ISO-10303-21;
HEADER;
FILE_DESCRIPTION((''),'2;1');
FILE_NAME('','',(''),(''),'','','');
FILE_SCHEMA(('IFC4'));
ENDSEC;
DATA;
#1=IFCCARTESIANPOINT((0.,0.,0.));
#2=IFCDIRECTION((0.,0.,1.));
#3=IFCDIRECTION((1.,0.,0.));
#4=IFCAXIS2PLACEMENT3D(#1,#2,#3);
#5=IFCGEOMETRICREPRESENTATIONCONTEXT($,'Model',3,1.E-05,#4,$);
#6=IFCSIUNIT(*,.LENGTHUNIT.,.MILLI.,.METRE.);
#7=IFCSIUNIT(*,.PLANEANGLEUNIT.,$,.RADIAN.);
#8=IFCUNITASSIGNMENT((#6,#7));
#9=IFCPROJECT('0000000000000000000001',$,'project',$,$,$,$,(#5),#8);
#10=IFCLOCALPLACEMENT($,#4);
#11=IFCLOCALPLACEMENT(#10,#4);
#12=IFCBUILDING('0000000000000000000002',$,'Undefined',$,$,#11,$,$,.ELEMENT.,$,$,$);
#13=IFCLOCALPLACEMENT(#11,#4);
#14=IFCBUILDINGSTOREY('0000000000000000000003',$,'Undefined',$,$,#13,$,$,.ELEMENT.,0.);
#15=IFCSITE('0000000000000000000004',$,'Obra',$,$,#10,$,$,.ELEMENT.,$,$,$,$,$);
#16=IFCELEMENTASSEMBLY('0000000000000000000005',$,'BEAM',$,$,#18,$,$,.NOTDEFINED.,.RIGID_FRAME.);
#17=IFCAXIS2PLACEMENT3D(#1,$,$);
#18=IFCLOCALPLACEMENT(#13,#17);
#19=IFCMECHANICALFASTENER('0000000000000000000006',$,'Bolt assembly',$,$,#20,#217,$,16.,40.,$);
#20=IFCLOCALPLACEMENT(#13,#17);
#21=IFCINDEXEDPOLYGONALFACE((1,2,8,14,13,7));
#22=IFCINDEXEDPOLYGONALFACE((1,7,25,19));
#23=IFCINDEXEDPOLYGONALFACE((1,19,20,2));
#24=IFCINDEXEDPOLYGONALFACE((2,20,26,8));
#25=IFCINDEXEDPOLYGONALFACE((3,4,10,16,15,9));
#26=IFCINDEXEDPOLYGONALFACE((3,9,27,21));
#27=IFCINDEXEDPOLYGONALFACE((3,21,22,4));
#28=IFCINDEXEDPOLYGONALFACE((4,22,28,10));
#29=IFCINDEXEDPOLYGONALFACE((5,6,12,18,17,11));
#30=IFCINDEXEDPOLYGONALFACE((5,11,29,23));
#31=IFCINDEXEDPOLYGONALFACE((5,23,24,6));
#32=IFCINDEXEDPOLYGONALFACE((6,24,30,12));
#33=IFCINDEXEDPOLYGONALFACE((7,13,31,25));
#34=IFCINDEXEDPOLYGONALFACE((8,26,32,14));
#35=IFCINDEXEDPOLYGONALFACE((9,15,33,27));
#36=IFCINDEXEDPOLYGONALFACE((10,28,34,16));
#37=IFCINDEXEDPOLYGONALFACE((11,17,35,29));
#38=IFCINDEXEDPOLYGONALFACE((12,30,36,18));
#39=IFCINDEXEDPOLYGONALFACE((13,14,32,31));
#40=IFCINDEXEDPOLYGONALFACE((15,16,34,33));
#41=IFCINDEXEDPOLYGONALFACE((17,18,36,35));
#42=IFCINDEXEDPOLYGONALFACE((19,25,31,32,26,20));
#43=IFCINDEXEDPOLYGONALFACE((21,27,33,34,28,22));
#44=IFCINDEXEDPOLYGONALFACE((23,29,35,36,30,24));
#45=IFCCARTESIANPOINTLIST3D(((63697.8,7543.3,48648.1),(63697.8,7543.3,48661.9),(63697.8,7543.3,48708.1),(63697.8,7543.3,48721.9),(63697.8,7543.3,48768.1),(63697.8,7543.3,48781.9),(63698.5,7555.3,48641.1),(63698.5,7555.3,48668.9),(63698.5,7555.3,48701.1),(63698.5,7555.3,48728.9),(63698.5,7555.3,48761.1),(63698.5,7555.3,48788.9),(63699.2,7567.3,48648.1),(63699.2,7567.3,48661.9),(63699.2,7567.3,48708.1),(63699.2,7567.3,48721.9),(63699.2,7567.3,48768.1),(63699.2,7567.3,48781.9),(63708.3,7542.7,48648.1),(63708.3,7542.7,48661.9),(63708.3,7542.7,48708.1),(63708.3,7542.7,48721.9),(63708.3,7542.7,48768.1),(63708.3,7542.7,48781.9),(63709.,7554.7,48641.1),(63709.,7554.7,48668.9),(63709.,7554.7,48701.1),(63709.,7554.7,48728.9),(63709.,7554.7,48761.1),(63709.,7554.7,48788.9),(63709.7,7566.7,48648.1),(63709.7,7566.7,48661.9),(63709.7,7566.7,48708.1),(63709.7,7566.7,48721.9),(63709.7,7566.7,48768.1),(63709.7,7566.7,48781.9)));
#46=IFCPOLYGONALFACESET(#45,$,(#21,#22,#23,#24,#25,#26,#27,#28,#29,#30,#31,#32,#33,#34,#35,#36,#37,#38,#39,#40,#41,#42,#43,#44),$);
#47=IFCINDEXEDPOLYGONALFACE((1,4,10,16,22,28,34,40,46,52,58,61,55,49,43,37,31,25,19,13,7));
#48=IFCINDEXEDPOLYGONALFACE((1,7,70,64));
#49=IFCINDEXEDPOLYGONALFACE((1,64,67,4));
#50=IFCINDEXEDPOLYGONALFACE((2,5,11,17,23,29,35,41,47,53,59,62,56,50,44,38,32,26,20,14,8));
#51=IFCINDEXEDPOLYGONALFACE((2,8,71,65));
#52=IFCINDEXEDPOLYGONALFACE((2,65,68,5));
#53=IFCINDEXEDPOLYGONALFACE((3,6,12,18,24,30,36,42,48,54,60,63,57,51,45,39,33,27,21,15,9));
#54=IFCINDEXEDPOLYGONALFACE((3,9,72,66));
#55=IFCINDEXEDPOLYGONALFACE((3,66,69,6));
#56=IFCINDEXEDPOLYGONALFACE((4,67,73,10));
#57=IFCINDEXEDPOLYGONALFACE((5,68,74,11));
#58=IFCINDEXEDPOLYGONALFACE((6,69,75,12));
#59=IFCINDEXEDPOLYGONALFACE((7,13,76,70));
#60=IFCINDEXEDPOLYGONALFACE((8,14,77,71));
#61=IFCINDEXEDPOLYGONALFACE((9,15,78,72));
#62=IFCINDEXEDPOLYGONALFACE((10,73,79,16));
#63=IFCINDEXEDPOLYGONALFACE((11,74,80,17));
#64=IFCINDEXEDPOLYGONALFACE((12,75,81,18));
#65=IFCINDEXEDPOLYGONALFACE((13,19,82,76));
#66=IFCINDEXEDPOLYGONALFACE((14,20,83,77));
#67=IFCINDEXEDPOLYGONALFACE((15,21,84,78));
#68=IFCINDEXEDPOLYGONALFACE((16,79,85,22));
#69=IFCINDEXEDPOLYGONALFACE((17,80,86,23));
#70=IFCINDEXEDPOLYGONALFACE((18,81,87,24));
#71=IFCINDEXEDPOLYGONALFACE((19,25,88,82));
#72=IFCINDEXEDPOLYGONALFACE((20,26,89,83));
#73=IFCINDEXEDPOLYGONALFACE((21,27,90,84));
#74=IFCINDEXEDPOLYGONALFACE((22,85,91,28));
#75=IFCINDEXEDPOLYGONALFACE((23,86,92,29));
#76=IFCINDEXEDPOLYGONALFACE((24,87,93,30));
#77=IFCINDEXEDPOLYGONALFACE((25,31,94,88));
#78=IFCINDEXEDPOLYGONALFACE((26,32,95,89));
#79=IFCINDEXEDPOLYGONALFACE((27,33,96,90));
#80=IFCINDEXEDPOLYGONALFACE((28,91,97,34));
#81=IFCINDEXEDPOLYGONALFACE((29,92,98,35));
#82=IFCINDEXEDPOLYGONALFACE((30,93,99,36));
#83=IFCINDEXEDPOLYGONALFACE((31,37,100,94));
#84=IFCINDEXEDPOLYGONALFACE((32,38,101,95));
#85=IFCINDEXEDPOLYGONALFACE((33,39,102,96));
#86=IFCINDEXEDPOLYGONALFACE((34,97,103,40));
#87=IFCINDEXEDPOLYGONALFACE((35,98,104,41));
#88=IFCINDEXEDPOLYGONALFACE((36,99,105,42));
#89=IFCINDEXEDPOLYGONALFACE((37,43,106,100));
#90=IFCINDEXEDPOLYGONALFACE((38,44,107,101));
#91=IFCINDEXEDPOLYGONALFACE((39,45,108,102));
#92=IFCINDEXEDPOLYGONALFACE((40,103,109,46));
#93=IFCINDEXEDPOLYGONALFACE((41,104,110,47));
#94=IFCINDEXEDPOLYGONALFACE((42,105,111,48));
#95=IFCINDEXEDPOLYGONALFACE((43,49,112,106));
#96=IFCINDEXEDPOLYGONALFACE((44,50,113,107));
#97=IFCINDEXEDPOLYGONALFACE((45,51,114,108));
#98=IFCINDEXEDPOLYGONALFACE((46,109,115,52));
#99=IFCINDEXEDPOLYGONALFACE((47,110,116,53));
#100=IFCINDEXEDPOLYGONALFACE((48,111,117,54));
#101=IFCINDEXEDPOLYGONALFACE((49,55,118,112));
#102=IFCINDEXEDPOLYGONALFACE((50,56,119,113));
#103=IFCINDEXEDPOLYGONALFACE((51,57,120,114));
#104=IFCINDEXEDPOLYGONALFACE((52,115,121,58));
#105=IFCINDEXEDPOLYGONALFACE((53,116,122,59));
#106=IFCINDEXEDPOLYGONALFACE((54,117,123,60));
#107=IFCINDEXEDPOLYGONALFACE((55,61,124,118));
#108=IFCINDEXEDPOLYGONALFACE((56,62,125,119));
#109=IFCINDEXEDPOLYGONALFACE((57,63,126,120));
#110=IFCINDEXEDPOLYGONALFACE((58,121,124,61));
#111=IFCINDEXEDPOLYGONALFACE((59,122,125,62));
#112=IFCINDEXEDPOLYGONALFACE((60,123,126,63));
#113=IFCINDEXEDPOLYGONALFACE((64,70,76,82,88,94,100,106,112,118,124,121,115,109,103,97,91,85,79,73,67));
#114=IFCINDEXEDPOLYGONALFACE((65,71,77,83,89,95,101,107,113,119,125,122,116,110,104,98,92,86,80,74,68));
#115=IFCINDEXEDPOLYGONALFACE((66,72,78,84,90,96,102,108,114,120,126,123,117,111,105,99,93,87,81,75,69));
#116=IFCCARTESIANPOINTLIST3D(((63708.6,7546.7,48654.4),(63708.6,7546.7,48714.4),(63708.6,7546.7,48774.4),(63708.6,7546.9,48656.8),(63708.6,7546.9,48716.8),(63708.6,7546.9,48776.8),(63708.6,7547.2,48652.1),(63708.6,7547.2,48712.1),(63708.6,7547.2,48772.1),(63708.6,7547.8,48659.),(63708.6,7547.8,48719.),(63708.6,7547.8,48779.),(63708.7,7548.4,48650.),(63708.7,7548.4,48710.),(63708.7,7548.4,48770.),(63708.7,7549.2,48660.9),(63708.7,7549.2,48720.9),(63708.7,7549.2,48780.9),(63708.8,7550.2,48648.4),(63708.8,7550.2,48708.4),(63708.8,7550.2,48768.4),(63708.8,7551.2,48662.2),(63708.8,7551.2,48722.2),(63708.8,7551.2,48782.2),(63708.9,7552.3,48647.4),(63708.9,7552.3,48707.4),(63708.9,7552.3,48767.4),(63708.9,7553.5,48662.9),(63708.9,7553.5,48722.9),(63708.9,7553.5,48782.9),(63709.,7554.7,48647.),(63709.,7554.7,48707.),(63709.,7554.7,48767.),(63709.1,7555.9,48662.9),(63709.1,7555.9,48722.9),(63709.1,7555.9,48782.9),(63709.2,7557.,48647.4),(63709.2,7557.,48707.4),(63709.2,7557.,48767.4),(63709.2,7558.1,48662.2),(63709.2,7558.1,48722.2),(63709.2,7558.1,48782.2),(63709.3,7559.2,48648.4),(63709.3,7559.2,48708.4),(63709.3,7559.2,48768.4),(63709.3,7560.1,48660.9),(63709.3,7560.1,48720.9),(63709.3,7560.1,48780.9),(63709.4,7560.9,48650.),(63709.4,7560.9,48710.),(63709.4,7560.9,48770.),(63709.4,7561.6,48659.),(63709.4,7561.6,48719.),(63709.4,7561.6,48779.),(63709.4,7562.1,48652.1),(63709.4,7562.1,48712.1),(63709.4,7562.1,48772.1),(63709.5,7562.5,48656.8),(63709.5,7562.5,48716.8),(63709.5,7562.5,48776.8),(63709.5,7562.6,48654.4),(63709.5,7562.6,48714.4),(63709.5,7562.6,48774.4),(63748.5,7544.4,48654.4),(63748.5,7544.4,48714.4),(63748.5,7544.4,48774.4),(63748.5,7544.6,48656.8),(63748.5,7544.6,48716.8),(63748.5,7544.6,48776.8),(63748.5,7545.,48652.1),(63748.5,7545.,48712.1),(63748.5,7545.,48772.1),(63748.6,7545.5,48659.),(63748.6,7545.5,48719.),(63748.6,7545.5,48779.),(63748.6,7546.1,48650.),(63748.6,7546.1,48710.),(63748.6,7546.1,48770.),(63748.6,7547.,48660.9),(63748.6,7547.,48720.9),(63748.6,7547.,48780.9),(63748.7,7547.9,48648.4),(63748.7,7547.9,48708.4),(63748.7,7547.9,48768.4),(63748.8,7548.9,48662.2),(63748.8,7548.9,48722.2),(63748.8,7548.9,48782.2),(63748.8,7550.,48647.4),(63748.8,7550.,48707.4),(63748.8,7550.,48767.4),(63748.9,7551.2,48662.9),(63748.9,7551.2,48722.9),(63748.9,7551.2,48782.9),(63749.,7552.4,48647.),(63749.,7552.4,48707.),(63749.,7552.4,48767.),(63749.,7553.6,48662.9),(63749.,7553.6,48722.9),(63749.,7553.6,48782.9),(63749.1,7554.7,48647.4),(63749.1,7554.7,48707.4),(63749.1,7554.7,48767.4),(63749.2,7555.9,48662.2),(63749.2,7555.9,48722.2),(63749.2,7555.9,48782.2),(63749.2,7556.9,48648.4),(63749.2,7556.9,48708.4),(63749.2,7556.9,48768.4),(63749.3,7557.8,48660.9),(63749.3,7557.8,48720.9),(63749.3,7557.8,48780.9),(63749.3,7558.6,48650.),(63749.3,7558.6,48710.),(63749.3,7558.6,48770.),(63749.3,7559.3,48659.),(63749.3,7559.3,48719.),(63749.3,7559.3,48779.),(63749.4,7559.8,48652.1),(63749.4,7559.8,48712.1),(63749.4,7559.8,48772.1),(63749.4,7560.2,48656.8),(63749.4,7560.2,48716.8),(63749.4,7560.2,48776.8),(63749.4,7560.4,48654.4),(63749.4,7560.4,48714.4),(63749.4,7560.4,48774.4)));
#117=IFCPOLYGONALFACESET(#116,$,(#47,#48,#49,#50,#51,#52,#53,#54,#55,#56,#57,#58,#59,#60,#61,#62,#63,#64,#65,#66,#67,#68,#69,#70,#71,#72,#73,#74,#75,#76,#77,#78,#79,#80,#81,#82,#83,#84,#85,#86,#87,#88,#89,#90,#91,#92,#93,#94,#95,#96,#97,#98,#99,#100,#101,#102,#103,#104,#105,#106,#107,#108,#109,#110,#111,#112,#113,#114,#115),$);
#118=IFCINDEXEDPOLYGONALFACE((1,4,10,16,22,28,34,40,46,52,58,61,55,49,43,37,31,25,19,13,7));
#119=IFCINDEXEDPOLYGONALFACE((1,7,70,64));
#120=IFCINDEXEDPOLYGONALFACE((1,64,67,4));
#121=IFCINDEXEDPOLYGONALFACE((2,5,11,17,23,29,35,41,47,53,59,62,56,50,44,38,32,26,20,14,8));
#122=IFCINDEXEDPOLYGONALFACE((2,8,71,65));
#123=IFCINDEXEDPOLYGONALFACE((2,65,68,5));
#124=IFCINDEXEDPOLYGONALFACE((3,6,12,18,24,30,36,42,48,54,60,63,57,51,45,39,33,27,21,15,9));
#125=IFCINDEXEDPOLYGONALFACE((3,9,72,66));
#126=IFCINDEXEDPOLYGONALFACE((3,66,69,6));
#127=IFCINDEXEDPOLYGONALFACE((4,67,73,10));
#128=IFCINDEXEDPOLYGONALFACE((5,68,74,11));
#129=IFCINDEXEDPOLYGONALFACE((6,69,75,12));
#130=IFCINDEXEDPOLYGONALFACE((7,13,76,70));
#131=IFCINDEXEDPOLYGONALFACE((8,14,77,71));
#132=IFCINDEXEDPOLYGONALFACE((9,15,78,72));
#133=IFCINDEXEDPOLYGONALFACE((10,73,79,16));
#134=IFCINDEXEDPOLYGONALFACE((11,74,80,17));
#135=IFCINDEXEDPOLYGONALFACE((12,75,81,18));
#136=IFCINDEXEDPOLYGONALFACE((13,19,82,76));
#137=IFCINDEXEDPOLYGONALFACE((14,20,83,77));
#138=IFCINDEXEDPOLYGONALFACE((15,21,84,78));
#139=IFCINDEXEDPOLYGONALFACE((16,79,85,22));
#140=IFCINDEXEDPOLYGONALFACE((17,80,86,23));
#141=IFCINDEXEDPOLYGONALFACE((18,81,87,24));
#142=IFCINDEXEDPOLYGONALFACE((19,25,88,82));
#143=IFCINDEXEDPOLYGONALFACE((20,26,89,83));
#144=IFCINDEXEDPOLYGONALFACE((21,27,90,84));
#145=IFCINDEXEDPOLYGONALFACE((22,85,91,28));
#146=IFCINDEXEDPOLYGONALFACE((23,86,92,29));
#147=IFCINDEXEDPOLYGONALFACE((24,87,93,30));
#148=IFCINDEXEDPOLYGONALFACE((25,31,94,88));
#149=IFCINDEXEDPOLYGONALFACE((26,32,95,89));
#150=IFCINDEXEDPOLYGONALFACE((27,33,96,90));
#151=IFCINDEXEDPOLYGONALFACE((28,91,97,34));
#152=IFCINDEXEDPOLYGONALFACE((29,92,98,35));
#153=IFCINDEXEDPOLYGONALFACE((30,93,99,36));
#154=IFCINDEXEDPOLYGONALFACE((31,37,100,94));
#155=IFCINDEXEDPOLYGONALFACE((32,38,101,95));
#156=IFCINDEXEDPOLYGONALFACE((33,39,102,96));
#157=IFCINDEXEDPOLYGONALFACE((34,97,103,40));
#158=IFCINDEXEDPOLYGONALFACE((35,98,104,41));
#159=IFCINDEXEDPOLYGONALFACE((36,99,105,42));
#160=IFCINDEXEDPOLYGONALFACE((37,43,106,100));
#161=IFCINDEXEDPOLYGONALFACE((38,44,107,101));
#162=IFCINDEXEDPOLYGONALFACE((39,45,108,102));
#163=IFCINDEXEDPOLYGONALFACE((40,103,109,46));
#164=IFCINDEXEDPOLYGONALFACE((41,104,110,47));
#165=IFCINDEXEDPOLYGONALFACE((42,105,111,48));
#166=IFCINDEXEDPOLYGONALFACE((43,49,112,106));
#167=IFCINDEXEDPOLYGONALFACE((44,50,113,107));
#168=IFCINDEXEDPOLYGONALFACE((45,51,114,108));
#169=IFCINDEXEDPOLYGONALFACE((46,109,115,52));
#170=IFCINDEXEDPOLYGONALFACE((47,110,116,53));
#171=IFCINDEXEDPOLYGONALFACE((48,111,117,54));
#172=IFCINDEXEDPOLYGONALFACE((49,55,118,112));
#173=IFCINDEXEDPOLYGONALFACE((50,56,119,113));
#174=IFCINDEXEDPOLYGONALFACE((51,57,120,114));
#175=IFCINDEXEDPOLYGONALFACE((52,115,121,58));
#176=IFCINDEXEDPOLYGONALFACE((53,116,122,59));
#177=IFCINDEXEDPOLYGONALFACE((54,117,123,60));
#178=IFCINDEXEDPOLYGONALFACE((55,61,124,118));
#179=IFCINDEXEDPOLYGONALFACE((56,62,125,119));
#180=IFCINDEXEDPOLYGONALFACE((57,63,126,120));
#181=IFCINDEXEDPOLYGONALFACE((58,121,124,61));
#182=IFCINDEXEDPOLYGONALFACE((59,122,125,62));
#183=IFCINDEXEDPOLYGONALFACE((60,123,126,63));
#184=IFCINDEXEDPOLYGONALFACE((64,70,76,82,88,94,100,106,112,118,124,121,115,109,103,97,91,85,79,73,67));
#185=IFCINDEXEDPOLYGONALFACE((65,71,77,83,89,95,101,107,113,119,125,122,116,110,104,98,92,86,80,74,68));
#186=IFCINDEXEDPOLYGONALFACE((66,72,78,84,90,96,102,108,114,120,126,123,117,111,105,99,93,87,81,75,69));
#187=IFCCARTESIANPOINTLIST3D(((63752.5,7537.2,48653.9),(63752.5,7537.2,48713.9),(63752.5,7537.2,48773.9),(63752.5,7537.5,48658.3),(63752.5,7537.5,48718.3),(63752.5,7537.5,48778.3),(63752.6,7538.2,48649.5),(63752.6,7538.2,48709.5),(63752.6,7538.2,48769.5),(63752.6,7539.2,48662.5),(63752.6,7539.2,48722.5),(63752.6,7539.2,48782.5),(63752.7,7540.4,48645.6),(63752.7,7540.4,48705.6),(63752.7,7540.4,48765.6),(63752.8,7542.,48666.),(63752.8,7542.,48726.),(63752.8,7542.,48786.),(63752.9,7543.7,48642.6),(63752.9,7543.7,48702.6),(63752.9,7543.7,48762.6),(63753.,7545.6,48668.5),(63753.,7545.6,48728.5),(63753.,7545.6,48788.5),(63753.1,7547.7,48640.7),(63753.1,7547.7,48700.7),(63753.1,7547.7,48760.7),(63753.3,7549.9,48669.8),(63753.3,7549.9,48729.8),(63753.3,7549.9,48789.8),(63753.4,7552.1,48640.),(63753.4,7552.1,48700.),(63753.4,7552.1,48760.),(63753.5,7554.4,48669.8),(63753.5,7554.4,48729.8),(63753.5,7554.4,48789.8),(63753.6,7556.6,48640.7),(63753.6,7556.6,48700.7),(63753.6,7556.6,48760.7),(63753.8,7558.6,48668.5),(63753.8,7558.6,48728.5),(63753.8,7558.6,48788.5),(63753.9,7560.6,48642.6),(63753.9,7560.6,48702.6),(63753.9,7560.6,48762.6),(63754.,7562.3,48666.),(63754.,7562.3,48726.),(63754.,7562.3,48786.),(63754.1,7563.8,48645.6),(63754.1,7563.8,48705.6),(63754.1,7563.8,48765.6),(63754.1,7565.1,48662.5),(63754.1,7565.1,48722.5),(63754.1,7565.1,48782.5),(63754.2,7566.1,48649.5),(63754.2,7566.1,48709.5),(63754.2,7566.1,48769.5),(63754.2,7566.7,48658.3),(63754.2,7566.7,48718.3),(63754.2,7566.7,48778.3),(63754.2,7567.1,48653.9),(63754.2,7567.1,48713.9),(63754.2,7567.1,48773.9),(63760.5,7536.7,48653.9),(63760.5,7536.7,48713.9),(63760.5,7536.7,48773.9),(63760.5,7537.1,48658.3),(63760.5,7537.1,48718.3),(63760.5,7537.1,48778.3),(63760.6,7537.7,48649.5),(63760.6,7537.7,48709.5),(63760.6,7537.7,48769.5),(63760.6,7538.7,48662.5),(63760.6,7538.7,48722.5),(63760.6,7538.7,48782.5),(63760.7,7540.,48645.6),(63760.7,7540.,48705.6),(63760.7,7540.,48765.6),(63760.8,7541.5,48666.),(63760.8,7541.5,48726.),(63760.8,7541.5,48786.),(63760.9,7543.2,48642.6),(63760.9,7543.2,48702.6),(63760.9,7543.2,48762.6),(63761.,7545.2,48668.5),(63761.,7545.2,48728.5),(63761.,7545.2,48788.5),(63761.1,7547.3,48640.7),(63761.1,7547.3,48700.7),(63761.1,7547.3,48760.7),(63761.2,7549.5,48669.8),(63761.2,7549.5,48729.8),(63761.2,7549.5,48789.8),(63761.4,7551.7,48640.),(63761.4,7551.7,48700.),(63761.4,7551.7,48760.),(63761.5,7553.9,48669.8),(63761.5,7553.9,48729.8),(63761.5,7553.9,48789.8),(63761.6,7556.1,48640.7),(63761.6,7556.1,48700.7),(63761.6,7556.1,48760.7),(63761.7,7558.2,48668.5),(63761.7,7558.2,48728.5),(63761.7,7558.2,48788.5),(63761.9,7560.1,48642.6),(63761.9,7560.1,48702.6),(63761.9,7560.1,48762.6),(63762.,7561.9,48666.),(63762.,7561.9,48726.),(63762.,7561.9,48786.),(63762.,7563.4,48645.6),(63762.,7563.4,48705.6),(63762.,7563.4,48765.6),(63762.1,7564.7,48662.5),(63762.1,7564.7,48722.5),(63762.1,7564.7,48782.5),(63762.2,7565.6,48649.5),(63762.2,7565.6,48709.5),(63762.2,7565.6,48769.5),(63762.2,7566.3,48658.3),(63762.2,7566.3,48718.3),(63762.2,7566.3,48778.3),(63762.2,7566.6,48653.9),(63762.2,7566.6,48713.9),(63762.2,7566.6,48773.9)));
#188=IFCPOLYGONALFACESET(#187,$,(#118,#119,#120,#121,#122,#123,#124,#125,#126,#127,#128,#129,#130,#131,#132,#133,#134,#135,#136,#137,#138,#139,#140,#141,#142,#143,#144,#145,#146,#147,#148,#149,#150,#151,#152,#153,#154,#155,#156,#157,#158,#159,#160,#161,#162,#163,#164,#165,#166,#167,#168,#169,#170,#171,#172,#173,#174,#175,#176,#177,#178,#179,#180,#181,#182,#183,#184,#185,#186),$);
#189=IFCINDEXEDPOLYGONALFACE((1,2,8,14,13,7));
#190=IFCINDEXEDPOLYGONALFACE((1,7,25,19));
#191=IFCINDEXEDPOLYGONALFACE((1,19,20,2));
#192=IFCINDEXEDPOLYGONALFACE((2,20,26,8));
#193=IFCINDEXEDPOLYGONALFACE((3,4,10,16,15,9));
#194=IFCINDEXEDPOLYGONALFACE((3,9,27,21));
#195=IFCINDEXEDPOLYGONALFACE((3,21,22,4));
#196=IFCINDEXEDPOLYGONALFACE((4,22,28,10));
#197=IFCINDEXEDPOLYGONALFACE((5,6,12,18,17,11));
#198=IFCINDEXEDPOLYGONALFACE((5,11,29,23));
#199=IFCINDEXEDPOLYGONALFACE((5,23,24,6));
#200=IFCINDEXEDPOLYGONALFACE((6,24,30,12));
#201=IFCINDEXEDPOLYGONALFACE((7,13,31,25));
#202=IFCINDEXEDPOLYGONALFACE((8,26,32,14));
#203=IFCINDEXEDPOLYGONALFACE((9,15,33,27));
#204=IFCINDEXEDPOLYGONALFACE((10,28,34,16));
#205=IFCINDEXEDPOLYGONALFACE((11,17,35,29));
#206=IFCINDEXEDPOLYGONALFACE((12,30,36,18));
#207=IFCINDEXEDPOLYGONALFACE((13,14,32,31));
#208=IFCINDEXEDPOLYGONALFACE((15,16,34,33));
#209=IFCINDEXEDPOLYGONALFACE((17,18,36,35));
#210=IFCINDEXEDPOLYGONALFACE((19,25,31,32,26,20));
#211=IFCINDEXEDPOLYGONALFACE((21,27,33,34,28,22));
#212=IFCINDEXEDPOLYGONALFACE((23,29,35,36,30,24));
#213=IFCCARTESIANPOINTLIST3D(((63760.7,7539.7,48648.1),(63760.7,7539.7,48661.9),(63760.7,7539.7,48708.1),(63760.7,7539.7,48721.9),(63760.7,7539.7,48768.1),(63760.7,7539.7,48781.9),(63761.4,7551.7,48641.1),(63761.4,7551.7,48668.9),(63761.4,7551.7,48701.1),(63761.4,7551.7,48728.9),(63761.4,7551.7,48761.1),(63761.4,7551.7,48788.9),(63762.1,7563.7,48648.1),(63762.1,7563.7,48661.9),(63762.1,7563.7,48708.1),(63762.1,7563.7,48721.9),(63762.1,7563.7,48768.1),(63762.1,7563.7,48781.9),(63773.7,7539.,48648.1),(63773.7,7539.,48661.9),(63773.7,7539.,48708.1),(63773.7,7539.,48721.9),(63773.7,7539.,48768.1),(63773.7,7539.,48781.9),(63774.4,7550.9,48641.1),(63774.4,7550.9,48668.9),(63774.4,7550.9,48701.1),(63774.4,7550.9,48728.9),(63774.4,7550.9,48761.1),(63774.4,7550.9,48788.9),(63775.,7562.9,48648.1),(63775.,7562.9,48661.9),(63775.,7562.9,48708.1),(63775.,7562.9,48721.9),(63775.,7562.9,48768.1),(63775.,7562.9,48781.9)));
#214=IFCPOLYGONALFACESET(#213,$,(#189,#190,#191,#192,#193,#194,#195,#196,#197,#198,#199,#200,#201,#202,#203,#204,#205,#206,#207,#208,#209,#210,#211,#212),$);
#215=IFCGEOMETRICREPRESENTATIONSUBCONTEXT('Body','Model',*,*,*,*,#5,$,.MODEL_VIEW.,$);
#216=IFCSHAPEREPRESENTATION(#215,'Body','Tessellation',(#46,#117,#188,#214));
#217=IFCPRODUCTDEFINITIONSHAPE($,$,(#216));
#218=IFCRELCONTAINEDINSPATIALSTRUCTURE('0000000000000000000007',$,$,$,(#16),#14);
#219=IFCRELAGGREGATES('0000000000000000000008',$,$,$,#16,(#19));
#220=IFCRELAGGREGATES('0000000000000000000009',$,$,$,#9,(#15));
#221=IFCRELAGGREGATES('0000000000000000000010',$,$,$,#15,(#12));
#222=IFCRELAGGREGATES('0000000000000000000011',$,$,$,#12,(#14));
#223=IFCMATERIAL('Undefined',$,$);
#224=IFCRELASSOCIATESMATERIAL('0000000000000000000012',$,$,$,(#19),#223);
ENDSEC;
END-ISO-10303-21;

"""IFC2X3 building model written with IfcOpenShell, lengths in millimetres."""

from ifc_helpers import new_model, si_unit, frame, origin_with_axes, origin_2d_with_axis, place, context, subcontext, project, spatial, polyline, circle, outline, extrude, source, transform, mapped, material, element, aggregate, save


model = new_model("IFC2X3")

# Units and contexts
model_context = context("Model", 3, precision=1e-05, world=origin_with_axes())
body_context = subcontext(model_context, "Body", "Model", "MODEL_VIEW")
ifc_project = project(units=[si_unit("LENGTHUNIT", "METRE", prefix="MILLI"), si_unit("PLANEANGLEUNIT", "RADIAN")], contexts=[model_context])

# Site, building, storey
site_placement = place(None, origin_with_axes())
site = spatial("IfcSite", under=ifc_project, at=site_placement, Name="Obra", CompositionType="ELEMENT")
building_placement = place(site_placement, origin_with_axes())
building = spatial("IfcBuilding", under=site, at=building_placement, Name="Undefined", CompositionType="ELEMENT")
storey_placement = place(building_placement, origin_with_axes())
storey = spatial("IfcBuildingStorey", under=building, at=storey_placement, Name="Undefined", CompositionType="ELEMENT", Elevation=0.0)

# Shared definitions
ifc_material_1 = material(Name="Undefined")
shared_shape_1 = source(origin_with_axes(), body_context, "Body", "SweptSolid", [
    extrude(outline(polyline([(13.9, 0.0), (6.9, 12.0), (-6.9, 12.0), (-13.9, 0.0), (-6.9, -12.0), (6.9, -12.0), (13.9, 0.0)])), frame((0.0, -19.7, 0.0), z_axis=(0.0, 1.0, 0.0), x_axis=(1.0, 0.0, 0.0)), (0.0, 0.0, 1.0), 10.6),
    extrude(circle(Radius=8.0, at=origin_2d_with_axis()), frame((0.0, -9.1, 0.0), z_axis=(0.0, 1.0, 0.0), x_axis=(1.0, 0.0, 0.0)), (0.0, 0.0, 1.0), 40.0),
    extrude(circle(Radius=15.0, at=origin_2d_with_axis()), frame((0.0, 35.3, 0.0), z_axis=(0.0, 1.0, 0.0), x_axis=(1.0, 0.0, 0.0)), (0.0, 0.0, 1.0), 8.0),
    extrude(outline(polyline([(13.9, 0.0), (6.9, 12.0), (-6.9, 12.0), (-13.9, 0.0), (-6.9, -12.0), (6.9, -12.0), (13.9, 0.0)])), frame((0.0, 43.3, 0.0), z_axis=(0.0, 1.0, 0.0), x_axis=(1.0, 0.0, 0.0)), (0.0, 0.0, 1.0), 13.0),
])

# Element assembly, mechanical fastener
assembly_1_placement = place(storey_placement, origin_with_axes())
assembly_1 = element("IfcElementAssembly", 1, at=assembly_1_placement, inside=storey, Name="BEAM", AssemblyPlace="NOTDEFINED", PredefinedType="RIGID_FRAME")
mechanical_fastener_1_placement = place(assembly_1_placement, frame((63721.0, 7604.1, 48835.0), z_axis=(-0.05711, -0.998368, 0.0), x_axis=(0.0, 0.0, -1.0)))
mechanical_fastener_1 = element("IfcMechanicalFastener", 2, at=mechanical_fastener_1_placement, material=ifc_material_1, Name="Bolt assembly", NominalDiameter=16.0, NominalLength=40.0, context=body_context, shape_type="MappedRepresentation", body=[
    mapped(shared_shape_1, transform((60.0, 0.0, 50.0))),
    mapped(shared_shape_1, transform((120.0, 0.0, 50.0))),
    mapped(shared_shape_1, transform((180.0, 0.0, 50.0))),
])
aggregate(assembly_1, [mechanical_fastener_1])

save(model, "model.ifc")
